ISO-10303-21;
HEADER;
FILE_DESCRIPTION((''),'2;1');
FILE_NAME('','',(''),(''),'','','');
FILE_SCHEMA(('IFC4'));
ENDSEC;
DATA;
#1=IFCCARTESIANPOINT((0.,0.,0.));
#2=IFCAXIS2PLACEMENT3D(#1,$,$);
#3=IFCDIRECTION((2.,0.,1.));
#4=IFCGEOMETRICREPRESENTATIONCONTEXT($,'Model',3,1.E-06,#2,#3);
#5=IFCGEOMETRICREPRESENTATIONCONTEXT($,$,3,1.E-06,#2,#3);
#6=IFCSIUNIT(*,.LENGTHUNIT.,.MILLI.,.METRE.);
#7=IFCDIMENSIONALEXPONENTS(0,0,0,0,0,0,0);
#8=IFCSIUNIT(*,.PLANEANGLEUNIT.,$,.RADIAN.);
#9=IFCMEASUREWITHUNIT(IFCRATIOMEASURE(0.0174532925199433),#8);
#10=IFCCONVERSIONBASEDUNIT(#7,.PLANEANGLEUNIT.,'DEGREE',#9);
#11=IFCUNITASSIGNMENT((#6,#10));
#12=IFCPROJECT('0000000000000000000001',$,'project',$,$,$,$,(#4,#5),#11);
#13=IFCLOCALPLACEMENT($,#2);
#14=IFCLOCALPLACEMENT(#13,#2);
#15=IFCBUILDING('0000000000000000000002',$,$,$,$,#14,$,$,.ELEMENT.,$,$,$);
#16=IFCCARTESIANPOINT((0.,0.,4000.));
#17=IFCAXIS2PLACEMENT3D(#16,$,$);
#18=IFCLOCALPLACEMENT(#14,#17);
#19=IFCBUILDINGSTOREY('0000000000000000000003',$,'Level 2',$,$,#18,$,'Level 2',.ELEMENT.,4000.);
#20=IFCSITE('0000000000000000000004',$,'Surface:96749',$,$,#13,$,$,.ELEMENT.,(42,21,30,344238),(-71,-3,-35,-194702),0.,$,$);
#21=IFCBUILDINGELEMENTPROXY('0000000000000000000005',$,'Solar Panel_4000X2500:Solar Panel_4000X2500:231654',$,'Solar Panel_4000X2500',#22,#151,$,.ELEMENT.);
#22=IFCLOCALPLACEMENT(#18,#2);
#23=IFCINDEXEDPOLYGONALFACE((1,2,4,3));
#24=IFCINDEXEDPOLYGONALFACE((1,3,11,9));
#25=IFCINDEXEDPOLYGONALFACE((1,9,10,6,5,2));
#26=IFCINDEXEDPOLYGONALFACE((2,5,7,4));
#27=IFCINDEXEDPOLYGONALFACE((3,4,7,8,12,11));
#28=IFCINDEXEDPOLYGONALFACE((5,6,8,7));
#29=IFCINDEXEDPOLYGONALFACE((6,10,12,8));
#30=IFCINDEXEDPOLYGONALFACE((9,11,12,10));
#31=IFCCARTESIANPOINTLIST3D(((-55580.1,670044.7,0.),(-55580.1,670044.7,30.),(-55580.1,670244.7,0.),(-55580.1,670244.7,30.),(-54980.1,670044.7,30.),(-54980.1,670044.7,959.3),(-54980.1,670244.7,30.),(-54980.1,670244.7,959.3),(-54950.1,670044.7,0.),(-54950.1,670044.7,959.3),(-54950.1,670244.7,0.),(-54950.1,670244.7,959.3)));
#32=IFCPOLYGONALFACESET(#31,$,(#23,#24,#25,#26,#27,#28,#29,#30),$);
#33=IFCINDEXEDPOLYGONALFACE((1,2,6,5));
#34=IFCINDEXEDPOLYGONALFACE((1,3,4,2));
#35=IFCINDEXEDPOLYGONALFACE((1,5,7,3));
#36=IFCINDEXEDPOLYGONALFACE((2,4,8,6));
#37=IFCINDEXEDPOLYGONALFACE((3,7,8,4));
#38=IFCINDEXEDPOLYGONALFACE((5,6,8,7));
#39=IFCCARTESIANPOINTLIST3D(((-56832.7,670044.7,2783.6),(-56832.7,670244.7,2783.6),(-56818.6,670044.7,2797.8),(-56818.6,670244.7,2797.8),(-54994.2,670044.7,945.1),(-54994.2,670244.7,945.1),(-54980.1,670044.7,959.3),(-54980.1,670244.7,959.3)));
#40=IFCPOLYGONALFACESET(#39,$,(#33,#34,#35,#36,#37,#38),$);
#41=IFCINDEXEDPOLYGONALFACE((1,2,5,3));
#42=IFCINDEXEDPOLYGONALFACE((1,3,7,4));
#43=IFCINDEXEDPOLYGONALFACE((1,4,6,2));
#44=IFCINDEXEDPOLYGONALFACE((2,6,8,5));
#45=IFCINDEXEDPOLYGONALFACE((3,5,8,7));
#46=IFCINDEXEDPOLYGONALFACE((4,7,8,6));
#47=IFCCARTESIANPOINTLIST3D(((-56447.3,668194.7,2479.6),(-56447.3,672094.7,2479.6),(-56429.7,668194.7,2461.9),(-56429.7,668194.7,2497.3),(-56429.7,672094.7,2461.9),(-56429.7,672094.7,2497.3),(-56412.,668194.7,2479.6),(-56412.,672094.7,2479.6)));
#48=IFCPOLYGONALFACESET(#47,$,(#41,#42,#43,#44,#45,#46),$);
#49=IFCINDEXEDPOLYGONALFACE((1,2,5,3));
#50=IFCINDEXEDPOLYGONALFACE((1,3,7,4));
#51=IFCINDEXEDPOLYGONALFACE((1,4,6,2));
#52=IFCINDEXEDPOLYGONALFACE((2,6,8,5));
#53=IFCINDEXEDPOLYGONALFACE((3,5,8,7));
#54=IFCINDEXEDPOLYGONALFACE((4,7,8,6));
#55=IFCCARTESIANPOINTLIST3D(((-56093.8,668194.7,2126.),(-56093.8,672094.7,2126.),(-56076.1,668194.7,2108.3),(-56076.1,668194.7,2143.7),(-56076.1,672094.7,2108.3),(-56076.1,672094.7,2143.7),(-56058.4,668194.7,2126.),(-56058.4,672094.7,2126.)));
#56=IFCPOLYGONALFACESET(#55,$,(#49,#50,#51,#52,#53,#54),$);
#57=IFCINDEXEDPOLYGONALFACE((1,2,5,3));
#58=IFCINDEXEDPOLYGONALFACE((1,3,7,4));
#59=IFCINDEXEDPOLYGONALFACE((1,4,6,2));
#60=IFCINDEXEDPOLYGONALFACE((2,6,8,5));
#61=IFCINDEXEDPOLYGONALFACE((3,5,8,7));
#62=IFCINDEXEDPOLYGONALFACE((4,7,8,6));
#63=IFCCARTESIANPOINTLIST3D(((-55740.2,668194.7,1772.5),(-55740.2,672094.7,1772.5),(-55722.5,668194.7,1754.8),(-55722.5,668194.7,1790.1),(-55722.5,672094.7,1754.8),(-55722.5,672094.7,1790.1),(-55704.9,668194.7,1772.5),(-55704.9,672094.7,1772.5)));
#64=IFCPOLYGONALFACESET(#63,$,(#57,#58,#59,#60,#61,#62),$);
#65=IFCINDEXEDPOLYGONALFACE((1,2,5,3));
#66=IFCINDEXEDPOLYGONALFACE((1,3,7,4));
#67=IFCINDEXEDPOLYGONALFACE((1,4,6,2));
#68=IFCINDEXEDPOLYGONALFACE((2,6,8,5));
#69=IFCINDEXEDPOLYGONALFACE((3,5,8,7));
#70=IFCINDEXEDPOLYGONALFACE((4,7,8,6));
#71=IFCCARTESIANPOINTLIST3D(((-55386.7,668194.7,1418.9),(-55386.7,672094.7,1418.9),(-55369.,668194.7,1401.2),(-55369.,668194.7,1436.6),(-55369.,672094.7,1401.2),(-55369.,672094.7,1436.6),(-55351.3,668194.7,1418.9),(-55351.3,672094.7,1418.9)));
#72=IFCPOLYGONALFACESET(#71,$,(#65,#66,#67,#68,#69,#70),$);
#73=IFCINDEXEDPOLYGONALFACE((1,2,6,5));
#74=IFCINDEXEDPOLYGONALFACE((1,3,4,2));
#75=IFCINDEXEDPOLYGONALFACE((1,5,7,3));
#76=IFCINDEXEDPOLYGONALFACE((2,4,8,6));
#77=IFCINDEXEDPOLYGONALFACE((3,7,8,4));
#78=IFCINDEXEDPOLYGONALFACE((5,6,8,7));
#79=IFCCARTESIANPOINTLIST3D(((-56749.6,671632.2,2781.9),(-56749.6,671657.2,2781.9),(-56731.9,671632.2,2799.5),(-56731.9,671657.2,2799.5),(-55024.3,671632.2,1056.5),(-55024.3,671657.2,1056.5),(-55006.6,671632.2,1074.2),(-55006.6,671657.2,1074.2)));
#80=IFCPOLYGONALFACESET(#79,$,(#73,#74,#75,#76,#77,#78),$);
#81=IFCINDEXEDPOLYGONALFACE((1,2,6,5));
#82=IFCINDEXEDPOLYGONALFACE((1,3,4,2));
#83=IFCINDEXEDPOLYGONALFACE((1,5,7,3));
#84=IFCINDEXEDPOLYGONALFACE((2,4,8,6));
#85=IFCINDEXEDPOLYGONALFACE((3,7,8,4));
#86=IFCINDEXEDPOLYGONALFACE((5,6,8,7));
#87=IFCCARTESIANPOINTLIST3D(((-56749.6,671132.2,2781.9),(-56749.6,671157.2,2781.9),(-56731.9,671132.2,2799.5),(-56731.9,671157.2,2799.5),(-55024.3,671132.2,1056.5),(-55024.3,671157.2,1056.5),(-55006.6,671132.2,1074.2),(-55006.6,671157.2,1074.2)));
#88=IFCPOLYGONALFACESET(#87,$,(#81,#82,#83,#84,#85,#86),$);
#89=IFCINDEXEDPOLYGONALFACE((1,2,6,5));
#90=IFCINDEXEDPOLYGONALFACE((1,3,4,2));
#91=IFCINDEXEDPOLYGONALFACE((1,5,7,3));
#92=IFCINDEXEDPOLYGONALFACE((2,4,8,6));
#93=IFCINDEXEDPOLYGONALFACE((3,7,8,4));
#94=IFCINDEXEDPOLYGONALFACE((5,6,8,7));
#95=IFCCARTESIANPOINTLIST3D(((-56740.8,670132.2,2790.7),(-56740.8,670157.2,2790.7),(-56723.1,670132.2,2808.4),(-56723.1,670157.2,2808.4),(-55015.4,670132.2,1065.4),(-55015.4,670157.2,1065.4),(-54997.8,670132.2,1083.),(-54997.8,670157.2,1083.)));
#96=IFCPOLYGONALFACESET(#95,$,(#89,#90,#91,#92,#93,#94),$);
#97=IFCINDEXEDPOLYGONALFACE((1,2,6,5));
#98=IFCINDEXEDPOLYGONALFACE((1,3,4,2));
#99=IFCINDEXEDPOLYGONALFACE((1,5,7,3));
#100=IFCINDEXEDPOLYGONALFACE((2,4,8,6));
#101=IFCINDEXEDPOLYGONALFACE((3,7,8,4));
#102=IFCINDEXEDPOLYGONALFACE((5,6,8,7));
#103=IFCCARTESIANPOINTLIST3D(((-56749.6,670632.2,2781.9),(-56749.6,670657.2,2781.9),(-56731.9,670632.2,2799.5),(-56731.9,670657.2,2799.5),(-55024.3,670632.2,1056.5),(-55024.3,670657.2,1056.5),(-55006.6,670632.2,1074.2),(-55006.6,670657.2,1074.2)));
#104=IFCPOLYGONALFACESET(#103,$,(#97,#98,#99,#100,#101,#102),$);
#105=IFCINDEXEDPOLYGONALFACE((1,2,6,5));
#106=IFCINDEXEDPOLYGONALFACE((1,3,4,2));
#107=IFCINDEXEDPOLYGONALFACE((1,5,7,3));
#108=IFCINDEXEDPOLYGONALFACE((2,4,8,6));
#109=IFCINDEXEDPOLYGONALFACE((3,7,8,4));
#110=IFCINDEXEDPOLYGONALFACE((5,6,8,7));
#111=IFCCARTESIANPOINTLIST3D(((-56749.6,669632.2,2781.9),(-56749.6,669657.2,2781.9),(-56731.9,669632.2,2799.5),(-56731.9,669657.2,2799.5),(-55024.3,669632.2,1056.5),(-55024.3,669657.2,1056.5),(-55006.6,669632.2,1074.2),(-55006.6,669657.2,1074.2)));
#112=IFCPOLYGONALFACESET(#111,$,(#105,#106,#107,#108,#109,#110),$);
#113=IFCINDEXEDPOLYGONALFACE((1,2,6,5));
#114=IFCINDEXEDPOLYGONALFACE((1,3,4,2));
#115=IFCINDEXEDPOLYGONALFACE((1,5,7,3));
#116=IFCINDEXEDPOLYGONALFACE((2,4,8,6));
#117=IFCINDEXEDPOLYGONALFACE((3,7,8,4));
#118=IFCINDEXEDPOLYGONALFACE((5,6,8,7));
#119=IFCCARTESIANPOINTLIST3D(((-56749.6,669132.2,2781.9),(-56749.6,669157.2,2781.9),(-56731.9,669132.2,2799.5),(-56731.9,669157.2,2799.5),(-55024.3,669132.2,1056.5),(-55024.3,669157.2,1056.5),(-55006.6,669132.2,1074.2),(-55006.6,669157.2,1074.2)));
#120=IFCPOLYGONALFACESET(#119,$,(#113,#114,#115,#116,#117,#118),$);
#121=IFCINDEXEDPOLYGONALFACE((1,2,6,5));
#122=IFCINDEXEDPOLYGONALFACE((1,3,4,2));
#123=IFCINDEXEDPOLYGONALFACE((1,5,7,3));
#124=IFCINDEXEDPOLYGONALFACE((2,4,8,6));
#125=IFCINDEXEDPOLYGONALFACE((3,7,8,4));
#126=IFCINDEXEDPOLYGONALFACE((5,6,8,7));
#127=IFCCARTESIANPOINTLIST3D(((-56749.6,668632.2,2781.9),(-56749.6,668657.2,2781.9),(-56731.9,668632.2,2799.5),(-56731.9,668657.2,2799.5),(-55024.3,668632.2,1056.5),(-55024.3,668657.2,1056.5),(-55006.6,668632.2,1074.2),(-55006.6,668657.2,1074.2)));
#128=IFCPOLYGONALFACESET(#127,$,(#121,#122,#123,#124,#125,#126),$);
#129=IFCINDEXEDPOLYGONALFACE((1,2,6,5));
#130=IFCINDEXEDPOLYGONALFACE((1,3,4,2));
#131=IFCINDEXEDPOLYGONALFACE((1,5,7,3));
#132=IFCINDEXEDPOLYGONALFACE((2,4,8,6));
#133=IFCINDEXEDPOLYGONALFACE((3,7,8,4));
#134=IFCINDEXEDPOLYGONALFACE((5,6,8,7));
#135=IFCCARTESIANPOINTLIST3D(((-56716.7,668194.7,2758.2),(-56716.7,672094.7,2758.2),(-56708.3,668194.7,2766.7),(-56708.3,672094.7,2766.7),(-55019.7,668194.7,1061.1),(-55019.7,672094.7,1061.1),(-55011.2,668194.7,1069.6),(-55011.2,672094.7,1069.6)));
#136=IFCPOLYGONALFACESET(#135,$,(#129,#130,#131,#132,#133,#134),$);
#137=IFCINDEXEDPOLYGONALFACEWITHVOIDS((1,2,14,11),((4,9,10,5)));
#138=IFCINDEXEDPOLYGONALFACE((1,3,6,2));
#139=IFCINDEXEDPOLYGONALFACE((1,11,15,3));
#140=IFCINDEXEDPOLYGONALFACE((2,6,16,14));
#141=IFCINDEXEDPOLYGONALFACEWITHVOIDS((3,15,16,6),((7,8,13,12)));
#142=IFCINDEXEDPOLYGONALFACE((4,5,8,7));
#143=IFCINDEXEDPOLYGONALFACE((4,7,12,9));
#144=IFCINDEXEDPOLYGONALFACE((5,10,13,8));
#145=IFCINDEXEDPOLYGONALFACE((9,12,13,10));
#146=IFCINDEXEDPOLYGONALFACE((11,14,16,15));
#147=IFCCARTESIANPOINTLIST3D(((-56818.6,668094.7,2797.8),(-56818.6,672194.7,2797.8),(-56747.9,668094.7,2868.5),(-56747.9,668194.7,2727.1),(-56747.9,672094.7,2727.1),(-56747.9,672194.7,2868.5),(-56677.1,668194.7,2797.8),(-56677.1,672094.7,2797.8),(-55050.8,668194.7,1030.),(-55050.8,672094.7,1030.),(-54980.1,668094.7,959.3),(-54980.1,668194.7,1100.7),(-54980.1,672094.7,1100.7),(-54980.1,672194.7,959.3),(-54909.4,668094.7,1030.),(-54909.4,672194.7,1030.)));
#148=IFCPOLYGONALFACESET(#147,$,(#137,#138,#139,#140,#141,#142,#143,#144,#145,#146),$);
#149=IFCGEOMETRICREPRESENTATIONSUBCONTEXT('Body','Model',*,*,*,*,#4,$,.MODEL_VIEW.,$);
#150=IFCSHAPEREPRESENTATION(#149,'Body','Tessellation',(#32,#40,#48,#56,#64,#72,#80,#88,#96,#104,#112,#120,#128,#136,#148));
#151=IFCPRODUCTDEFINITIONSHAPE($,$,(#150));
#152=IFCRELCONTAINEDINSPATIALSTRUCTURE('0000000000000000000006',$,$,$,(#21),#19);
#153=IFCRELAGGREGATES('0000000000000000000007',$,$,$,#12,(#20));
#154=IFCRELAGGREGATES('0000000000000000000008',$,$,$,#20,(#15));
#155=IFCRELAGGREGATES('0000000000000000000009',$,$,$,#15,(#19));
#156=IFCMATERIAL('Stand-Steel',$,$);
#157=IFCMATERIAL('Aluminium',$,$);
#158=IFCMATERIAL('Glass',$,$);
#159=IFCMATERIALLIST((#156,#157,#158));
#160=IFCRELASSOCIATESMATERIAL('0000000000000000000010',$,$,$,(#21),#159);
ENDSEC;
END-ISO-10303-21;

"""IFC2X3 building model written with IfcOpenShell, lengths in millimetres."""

from ifc_helpers import new_model, entity, si_unit, converted_unit, direction, frame, frame_2d, origin, origin_2d_with_axis, place, context, subcontext, project, spatial, polyline, rectangle, outline, extrude, source, transform, mapped, material, material_list, element, save


model = new_model("IFC2X3")

# Units and contexts
model_context = context("Model", 3, precision=1e-06, world=origin(), true_north=direction((2.0, 0.0, 1.0)))
context_of_model = context(None, 3, precision=1e-06, world=origin(), true_north=direction((2.0, 0.0, 1.0)))
body_context = subcontext(model_context, "Body", "Model", "MODEL_VIEW")
ifc_project = project(units=[si_unit("LENGTHUNIT", "METRE", prefix="MILLI"), converted_unit("PLANEANGLEUNIT", "DEGREE", entity("IfcRatioMeasure", 0.0174532925199433), si_unit("PLANEANGLEUNIT", "RADIAN"), dimensions=[0, 0, 0, 0, 0, 0, 0])], contexts=[model_context, context_of_model])

# Site, building, storey
site_placement = place(None, origin())
site = spatial("IfcSite", under=ifc_project, at=site_placement, Name="Surface:96749", CompositionType="ELEMENT", RefLatitude=(42, 21, 30, 344238), RefLongitude=(-71, -3, -35, -194702), RefElevation=0.0)
building_placement = place(site_placement, origin())
building = spatial("IfcBuilding", under=site, at=building_placement, CompositionType="ELEMENT")
storey_placement = place(building_placement, frame((0.0, 0.0, 4000.0)))
storey = spatial("IfcBuildingStorey", under=building, at=storey_placement, Name="Level 2", LongName="Level 2", CompositionType="ELEMENT", Elevation=4000.0)

# Building element proxy
ifc_material_1 = material(Name="Stand-Steel")
ifc_material_2 = material(Name="Aluminium")
ifc_material_3 = material(Name="Glass")
shared_shape = source(origin(), body_context, "Body", "SweptSolid", [
    extrude(outline(polyline([(-629.5, -220.0), (329.8, -220.0), (329.8, 410.0), (299.8, 410.0), (299.8, -190.0), (-629.5, -190.0), (-629.5, -220.0)])), frame((-190.0, -100.0, 299.8), z_axis=(0.0, 1.0, 0.0), x_axis=(0.0, 0.0, -1.0)), (0.0, 0.0, 1.0), 200.0),
    extrude(rectangle(XDim=20.0, YDim=200.0, at=frame_2d((0.0, 0.0), x_axis=(0.0, 1.0))), frame((-7.1, 0.0, 922.2), z_axis=(-0.707107, 0.0, 0.707107), x_axis=(0.0, 1.0, 0.0)), (0.0, 0.0, 1.0), 2600.0),
    extrude(rectangle(XDim=25.0, YDim=25.0, at=frame_2d((0.0, 0.0), x_axis=(1.0, 0.0))), frame((-1449.6, -1950.0, 2449.6), z_axis=(0.0, 1.0, 0.0), x_axis=(-0.707107, 0.0, -0.707107)), (0.0, 0.0, 1.0), 3900.0),
    extrude(rectangle(XDim=25.0, YDim=25.0, at=origin_2d_with_axis()), frame((-1096.0, -1950.0, 2096.0), z_axis=(0.0, 1.0, 0.0), x_axis=(-0.707107, 0.0, -0.707107)), (0.0, 0.0, 1.0), 3900.0),
    extrude(rectangle(XDim=25.0, YDim=25.0, at=origin_2d_with_axis()), frame((-742.5, -1950.0, 1742.5), z_axis=(0.0, 1.0, 0.0), x_axis=(-0.707107, 0.0, -0.707107)), (0.0, 0.0, 1.0), 3900.0),
    extrude(rectangle(XDim=25.0, YDim=25.0, at=frame_2d((0.0, 0.0), x_axis=(1.0, 0.0))), frame((-388.9, -1950.0, 1388.9), z_axis=(0.0, 1.0, 0.0), x_axis=(-0.707107, 0.0, -0.707107)), (0.0, 0.0, 1.0), 3900.0),
    extrude(rectangle(XDim=25.0, YDim=25.0, at=frame_2d((0.0, 0.0), x_axis=(0.0, 1.0))), frame((-35.4, 1500.0, 1035.4), z_axis=(-0.707107, 0.0, 0.707107), x_axis=(0.0, 1.0, 0.0)), (0.0, 0.0, 1.0), 2440.0),
    extrude(rectangle(XDim=25.0, YDim=25.0, at=frame_2d((0.0, 0.0), x_axis=(0.0, 1.0))), frame((-35.4, 1000.0, 1035.4), z_axis=(-0.707107, 0.0, 0.707107), x_axis=(0.0, 1.0, 0.0)), (0.0, 0.0, 1.0), 2440.0),
    extrude(rectangle(XDim=25.0, YDim=25.0, at=frame_2d((0.0, 0.0), x_axis=(0.0, 1.0))), frame((-26.5, 0.0, 1044.2), z_axis=(-0.707107, 0.0, 0.707107), x_axis=(0.0, -1.0, 0.0)), (0.0, 0.0, 1.0), 2440.0),
    extrude(rectangle(XDim=25.0, YDim=25.0, at=frame_2d((0.0, 0.0), x_axis=(0.0, 1.0))), frame((-35.4, 500.0, 1035.4), z_axis=(-0.707107, 0.0, 0.707107), x_axis=(0.0, 1.0, 0.0)), (0.0, 0.0, 1.0), 2440.0),
    extrude(rectangle(XDim=25.0, YDim=25.0, at=frame_2d((0.0, 0.0), x_axis=(0.0, 1.0))), frame((-35.4, -500.0, 1035.4), z_axis=(-0.707107, 0.0, 0.707107), x_axis=(0.0, 1.0, 0.0)), (0.0, 0.0, 1.0), 2440.0),
    extrude(rectangle(XDim=25.0, YDim=25.0, at=frame_2d((0.0, 0.0), x_axis=(0.0, 1.0))), frame((-35.4, -1000.0, 1035.4), z_axis=(-0.707107, 0.0, 0.707107), x_axis=(0.0, 1.0, 0.0)), (0.0, 0.0, 1.0), 2440.0),
    extrude(rectangle(XDim=25.0, YDim=25.0, at=frame_2d((0.0, 0.0), x_axis=(0.0, 1.0))), frame((-35.4, -1500.0, 1035.4), z_axis=(-0.707107, 0.0, 0.707107), x_axis=(0.0, 1.0, 0.0)), (0.0, 0.0, 1.0), 2440.0),
    extrude(rectangle(XDim=2400.0, YDim=12.0, at=frame_2d((0.0, 0.0), x_axis=(1.0, 0.0))), frame((-883.9, -1950.0, 1883.9), z_axis=(0.0, 1.0, 0.0), x_axis=(0.707107, 0.0, -0.707107)), (0.0, 0.0, 1.0), 3900.0),
    extrude(outline(polyline([(-2050.0, -1300.0), (2050.0, -1300.0), (2050.0, 1300.0), (-2050.0, 1300.0), (-2050.0, -1300.0)]), holes=[polyline([(1950.0, -1200.0), (-1950.0, -1200.0), (-1950.0, 1200.0), (1950.0, 1200.0), (1950.0, -1200.0)])]), frame((-919.2, 0.0, 1848.5), z_axis=(0.707107, 0.0, 0.707107), x_axis=(0.0, 1.0, 0.0)), (0.0, 0.0, 1.0), 100.0),
])
ifc_material_list_1 = material_list([ifc_material_1, ifc_material_2, ifc_material_3])
proxy_1_placement = place(storey_placement, frame((-54980.1, 670144.7, 30.0)))
element("IfcBuildingElementProxy", 1, at=proxy_1_placement, inside=storey, material=ifc_material_list_1, Name="Solar Panel_4000X2500:Solar Panel_4000X2500:231654", ObjectType="Solar Panel_4000X2500", CompositionType="ELEMENT", context=body_context, shape_type="MappedRepresentation", body=[
    mapped(shared_shape, transform((0.0, 0.0, 0.0), scale=1.0)),
])

save(model, "model.ifc")
